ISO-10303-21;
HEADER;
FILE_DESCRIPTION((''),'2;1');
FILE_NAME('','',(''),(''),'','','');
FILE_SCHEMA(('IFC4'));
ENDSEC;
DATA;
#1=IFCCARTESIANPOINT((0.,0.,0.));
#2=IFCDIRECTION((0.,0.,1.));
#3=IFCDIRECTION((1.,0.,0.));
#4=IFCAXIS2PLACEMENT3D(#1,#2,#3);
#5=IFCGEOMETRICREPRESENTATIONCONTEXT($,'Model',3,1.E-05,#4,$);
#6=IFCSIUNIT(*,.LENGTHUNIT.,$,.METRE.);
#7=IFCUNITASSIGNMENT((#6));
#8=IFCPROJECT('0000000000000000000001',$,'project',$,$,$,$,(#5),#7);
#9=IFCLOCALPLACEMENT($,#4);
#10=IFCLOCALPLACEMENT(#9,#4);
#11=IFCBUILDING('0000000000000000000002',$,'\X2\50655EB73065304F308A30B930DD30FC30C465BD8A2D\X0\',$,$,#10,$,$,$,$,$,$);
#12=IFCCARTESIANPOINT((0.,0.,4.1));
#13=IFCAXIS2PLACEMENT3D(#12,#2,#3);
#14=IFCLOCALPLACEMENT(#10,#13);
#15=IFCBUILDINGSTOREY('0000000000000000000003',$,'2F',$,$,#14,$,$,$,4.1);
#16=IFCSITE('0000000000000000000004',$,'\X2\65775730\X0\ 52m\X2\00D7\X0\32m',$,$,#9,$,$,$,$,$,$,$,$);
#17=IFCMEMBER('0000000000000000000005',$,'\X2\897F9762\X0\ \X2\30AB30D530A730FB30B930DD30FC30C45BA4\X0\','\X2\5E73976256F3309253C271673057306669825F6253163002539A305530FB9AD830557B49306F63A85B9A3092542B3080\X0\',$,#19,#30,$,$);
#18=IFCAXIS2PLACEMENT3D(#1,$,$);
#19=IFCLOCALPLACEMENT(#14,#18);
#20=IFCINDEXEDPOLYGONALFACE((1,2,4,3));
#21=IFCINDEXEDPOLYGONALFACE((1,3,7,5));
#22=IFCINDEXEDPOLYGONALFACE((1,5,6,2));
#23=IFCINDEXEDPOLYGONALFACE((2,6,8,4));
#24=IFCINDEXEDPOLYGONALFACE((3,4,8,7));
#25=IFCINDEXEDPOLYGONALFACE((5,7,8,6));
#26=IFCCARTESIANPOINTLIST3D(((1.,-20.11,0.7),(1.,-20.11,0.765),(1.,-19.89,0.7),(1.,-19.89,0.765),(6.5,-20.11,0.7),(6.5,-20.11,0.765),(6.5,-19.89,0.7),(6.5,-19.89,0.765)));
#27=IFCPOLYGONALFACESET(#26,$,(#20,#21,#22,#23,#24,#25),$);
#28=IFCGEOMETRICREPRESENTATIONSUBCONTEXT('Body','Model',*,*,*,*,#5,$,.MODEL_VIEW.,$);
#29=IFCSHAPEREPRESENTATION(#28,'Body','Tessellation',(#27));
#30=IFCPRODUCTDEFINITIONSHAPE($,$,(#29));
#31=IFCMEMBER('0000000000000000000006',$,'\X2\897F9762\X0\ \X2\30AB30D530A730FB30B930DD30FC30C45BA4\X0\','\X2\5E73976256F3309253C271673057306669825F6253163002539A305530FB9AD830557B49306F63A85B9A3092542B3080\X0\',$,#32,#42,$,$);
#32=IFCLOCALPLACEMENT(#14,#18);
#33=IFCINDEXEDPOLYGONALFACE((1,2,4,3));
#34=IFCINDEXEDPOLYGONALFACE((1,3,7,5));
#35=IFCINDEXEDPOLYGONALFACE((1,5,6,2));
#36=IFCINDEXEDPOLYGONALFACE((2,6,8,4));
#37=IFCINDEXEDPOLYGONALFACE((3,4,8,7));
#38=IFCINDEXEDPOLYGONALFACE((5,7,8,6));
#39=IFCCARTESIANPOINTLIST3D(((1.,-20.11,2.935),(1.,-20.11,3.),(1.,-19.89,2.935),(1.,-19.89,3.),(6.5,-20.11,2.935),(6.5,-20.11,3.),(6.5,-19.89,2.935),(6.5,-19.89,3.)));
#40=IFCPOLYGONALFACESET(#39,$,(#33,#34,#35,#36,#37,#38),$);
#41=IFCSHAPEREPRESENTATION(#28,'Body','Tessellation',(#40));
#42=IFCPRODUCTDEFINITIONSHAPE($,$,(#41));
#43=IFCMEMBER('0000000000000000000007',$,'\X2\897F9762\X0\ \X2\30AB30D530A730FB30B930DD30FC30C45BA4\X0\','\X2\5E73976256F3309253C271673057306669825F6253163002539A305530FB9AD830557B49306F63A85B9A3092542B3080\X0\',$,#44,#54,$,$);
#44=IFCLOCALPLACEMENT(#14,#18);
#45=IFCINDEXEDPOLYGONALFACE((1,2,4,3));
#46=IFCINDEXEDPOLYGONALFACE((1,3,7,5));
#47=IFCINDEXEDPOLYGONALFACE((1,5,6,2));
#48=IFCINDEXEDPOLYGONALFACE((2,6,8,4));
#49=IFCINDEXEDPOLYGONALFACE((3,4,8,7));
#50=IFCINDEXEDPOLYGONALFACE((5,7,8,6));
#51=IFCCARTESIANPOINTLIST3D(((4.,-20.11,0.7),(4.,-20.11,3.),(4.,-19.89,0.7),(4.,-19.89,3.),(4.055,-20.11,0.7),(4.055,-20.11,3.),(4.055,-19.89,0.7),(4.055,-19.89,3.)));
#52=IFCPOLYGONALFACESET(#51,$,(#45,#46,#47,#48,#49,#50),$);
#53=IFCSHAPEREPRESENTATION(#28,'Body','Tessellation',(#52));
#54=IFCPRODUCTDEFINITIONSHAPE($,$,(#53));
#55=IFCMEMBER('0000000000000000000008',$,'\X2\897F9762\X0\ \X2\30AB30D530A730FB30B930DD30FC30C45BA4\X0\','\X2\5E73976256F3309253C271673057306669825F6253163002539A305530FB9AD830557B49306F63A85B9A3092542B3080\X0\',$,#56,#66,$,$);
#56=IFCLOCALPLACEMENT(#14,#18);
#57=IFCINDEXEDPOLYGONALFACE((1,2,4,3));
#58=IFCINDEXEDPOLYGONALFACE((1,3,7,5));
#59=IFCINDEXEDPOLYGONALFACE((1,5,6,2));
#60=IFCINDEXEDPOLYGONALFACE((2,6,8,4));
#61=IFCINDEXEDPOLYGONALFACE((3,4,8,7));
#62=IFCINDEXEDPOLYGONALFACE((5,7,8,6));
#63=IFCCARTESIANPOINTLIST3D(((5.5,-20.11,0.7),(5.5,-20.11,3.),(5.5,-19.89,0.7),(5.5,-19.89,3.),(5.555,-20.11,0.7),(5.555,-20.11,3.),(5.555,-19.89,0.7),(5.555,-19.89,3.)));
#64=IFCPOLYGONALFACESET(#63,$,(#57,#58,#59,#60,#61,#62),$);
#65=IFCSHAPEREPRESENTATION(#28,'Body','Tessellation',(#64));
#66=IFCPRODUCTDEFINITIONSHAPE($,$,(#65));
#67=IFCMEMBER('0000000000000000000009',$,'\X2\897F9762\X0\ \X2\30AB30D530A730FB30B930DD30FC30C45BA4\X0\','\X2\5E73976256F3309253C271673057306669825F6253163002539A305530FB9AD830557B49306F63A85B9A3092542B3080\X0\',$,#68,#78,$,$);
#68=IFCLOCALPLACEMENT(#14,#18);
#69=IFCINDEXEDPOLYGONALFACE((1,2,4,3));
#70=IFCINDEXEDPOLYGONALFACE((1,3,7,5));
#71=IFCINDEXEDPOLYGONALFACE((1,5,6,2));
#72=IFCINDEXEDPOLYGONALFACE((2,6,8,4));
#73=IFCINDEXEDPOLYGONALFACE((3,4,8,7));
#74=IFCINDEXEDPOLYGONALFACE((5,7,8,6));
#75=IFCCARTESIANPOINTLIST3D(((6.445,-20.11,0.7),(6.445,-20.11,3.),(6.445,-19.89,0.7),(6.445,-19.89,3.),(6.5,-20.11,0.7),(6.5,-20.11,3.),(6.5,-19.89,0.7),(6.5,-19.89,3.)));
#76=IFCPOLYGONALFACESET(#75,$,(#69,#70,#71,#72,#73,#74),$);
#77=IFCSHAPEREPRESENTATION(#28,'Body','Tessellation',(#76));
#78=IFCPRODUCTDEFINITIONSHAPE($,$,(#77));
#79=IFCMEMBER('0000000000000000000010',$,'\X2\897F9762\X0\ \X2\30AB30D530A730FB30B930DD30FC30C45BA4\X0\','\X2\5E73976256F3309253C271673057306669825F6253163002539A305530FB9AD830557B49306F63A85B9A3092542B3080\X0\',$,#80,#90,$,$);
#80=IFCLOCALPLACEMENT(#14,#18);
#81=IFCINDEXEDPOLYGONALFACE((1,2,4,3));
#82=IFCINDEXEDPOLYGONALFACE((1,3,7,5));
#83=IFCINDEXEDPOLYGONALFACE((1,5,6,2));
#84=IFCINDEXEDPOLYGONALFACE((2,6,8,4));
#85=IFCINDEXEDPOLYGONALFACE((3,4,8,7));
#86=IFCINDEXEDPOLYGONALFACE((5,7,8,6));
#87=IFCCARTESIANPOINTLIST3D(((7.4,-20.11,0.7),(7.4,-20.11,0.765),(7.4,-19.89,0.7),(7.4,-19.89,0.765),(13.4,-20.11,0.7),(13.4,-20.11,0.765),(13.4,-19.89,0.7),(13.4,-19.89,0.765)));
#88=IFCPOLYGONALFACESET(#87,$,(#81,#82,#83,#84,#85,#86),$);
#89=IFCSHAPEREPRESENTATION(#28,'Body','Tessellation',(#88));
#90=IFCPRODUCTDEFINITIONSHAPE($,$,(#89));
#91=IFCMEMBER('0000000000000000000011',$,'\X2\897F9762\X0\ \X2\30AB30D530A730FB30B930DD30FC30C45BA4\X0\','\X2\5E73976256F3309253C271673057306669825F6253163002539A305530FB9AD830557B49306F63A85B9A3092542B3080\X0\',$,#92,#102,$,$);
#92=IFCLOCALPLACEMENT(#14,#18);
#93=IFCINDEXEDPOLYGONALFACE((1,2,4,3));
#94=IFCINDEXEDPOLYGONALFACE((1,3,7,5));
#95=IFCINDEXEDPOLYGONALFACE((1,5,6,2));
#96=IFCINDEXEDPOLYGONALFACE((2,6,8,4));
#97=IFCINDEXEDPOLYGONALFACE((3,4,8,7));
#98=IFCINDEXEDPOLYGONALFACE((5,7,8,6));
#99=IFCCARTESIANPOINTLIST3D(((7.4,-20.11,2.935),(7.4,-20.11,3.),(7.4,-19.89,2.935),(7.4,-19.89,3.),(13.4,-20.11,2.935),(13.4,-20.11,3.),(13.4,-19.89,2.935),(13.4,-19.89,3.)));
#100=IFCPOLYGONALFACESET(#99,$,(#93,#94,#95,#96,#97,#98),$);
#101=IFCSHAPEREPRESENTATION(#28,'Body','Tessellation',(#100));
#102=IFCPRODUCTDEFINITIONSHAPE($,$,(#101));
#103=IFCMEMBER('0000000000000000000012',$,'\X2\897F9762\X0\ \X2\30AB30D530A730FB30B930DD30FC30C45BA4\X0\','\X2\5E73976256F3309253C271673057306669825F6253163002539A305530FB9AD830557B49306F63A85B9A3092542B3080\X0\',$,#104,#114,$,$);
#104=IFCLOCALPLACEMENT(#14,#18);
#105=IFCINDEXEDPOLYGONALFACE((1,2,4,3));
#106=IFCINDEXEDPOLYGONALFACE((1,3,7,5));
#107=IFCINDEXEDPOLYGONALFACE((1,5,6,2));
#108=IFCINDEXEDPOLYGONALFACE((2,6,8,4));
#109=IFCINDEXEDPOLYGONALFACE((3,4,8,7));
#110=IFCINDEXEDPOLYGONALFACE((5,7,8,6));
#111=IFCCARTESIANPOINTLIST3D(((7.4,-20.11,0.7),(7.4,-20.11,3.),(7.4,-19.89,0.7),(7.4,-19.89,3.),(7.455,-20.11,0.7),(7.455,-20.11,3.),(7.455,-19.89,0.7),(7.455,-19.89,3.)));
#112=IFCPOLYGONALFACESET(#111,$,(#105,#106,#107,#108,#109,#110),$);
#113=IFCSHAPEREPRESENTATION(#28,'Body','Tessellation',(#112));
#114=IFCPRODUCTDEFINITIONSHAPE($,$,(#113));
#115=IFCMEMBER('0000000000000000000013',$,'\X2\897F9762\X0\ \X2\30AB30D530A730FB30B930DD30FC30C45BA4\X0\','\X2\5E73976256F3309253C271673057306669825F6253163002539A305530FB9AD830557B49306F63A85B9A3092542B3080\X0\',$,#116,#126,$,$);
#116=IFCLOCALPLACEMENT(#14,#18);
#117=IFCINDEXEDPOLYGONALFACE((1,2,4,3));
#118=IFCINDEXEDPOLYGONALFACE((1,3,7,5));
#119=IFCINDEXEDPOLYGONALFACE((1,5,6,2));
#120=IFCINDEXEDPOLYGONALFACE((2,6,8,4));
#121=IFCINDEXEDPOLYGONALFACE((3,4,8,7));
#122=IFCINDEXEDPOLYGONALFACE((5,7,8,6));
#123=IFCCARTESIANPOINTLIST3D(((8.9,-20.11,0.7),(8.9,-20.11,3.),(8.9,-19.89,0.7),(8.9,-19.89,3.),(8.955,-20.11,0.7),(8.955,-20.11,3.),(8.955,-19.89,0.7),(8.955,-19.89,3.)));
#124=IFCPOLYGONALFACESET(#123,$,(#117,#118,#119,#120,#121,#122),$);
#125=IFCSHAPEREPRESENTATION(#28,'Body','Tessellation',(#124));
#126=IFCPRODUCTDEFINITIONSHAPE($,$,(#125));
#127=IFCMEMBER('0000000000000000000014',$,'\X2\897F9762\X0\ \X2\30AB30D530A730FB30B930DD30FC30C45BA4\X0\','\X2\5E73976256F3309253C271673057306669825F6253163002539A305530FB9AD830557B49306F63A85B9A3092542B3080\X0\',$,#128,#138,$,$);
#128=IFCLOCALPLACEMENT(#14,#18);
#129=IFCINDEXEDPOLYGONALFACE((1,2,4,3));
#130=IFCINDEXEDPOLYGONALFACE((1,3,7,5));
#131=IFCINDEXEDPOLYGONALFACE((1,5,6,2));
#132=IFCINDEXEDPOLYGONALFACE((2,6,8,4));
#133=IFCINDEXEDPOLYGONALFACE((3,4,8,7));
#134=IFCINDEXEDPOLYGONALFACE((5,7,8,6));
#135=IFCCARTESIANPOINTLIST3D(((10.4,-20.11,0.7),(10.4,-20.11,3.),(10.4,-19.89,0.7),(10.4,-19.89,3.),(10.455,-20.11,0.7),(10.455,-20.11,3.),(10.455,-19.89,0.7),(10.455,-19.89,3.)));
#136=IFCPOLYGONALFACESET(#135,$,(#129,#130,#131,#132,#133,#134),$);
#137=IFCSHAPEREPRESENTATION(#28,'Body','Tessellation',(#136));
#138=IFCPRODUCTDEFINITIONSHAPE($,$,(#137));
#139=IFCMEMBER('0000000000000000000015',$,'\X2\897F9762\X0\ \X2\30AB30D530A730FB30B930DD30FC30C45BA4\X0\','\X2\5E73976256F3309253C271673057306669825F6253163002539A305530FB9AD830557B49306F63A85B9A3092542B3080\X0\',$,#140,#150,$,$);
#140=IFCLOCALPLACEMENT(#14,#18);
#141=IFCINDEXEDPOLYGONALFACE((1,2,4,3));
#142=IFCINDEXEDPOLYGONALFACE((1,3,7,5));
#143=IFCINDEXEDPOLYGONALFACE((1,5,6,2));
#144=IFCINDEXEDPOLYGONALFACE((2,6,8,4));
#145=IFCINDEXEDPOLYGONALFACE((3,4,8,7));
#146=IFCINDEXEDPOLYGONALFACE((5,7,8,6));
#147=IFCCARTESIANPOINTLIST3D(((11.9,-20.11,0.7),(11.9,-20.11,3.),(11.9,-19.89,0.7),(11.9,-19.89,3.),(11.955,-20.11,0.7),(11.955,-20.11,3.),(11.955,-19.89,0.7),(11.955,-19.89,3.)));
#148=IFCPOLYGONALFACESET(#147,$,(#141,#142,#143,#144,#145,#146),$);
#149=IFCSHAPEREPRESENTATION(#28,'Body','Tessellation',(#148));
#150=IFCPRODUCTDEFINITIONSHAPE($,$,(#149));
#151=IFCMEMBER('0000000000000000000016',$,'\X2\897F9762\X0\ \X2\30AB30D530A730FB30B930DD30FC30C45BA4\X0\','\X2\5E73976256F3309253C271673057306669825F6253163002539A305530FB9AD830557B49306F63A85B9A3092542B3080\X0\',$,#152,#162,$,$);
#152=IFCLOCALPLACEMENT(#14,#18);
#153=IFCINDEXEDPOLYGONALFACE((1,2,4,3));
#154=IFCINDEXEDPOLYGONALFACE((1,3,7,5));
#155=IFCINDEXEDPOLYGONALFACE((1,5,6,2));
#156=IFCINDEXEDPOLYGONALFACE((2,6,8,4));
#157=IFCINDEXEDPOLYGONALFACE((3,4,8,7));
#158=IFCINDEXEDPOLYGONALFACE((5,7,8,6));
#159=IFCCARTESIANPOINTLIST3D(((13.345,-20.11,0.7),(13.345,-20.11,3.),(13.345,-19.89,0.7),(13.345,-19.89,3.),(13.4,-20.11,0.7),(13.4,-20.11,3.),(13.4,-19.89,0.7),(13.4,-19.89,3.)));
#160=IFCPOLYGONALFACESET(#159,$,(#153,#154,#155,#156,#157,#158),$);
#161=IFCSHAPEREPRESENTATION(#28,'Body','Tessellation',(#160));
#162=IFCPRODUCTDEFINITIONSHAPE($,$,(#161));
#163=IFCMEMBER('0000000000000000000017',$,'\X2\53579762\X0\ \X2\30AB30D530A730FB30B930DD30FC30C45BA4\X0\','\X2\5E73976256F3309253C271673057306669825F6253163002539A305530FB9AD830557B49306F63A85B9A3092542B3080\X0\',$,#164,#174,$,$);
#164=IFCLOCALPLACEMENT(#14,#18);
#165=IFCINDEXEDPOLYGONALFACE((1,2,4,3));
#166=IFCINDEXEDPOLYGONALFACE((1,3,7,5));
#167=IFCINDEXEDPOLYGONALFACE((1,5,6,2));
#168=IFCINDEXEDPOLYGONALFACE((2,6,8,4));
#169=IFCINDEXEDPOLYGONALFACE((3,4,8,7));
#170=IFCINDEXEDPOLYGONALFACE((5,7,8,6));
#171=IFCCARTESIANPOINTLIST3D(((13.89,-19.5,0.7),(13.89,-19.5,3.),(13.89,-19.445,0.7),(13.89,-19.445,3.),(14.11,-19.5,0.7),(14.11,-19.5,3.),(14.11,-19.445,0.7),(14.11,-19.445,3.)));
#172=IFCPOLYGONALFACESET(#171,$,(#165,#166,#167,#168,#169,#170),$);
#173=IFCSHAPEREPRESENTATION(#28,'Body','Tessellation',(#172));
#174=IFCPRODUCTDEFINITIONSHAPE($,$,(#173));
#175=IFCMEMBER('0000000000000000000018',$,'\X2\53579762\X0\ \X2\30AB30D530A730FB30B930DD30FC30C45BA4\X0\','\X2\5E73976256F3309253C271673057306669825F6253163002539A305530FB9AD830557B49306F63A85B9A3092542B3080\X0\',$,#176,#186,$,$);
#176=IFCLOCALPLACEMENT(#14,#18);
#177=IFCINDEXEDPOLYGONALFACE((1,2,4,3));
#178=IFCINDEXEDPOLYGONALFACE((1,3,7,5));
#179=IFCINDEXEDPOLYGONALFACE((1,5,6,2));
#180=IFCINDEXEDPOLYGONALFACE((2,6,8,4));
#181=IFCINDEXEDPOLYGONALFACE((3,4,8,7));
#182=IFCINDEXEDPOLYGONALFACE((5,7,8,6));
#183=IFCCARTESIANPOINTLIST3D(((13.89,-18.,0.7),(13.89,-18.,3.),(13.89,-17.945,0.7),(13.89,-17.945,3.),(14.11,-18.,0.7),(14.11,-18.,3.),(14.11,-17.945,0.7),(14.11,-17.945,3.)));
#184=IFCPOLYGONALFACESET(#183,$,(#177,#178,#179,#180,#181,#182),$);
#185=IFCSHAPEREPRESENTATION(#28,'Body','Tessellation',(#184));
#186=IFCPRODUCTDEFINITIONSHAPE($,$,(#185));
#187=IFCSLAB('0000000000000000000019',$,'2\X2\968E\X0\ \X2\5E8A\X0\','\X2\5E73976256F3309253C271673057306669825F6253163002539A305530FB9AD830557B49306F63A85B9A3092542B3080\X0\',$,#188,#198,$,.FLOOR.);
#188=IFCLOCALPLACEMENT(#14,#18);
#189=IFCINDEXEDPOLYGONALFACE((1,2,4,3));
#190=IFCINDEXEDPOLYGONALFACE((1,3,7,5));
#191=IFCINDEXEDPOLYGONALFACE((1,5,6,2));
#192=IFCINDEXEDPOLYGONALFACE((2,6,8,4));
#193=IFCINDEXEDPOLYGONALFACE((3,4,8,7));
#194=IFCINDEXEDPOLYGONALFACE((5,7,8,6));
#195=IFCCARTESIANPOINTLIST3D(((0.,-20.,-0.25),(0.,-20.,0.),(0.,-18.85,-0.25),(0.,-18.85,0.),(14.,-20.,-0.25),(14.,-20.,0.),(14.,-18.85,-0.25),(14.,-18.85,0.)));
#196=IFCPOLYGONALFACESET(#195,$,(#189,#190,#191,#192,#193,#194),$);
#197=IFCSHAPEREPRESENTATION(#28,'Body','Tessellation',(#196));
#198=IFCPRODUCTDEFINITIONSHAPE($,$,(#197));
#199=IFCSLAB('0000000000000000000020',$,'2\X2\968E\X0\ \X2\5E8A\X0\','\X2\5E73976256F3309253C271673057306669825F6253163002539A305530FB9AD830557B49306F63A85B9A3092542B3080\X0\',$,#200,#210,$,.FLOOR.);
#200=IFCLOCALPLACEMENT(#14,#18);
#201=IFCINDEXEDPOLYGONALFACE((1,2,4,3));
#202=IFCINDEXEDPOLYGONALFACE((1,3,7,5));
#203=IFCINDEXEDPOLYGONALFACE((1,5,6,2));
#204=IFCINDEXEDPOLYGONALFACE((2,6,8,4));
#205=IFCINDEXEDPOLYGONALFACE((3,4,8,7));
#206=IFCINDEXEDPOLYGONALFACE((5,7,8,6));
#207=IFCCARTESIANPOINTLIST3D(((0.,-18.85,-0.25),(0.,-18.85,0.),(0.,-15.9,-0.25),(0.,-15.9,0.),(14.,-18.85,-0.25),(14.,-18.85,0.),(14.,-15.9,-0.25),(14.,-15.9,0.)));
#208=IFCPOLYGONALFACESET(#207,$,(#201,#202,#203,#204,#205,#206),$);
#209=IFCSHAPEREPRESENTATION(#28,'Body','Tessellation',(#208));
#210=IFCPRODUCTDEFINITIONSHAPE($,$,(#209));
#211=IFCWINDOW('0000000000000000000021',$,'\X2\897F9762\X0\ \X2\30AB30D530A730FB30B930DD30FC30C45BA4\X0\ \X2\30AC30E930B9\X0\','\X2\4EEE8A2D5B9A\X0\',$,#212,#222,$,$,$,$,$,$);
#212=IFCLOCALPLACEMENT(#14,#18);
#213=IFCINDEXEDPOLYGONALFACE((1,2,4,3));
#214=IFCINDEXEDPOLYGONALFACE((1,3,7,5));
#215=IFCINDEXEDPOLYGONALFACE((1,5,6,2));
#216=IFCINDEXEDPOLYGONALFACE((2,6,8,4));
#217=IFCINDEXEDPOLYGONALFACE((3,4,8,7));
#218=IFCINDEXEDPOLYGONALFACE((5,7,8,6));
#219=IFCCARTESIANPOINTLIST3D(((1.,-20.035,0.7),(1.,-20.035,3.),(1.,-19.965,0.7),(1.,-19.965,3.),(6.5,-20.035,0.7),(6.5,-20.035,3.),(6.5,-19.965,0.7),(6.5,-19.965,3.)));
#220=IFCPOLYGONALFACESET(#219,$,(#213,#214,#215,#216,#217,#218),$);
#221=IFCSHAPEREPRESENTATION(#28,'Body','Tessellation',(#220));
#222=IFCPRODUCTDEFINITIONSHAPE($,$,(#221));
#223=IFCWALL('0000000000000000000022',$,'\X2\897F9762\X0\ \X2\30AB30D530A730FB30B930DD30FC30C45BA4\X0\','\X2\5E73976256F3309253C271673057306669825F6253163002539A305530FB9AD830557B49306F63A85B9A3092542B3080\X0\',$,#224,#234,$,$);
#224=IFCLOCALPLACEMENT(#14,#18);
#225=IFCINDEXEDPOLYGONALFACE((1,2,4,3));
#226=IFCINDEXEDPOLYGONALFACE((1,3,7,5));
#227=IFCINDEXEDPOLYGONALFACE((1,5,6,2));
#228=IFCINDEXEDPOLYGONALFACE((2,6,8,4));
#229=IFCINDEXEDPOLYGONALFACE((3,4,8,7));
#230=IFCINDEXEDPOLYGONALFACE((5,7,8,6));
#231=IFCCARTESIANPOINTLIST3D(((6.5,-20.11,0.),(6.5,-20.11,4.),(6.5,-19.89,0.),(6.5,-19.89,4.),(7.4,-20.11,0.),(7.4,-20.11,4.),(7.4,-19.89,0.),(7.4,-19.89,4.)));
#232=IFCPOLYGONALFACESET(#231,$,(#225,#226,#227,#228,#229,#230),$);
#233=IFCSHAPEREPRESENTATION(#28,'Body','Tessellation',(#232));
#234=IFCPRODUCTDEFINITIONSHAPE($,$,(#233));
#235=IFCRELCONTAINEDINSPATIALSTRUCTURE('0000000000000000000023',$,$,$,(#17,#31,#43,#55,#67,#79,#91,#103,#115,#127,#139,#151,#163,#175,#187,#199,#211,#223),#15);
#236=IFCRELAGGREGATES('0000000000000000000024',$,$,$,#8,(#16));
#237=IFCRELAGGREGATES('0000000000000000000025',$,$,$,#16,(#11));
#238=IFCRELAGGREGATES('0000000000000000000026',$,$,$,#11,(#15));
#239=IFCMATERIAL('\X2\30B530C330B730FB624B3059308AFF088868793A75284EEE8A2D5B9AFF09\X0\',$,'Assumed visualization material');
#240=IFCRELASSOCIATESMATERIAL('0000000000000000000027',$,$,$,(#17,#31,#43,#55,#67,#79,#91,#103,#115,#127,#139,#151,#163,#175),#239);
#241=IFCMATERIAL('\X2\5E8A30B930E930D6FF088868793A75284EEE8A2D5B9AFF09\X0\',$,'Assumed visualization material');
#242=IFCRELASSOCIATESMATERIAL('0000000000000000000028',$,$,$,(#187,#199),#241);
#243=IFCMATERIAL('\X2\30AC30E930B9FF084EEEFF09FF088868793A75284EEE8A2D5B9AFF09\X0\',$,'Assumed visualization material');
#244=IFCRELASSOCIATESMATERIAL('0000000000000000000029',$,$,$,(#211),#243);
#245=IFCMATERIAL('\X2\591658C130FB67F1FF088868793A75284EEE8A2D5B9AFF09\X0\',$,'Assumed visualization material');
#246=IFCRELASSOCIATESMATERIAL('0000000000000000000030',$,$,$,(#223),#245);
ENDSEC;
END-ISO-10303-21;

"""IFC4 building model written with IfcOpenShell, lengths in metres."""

from ifc_helpers import new_model, si_unit, frame, origin_with_axes, place, context, subcontext, project, spatial, rectangle, extrude, material, element, save


model = new_model("IFC4")

# Units and contexts
model_context = context("Model", 3, precision=1e-05, world=origin_with_axes())
body_context = subcontext(model_context, "Body", "Model", "MODEL_VIEW")
ifc_project = project(units=[si_unit("LENGTHUNIT", "METRE")], contexts=[model_context])

# Site, building, storey
site_placement = place(None, origin_with_axes())
site = spatial("IfcSite", under=ifc_project, at=site_placement, Name="敷地 52m×32m")
building_placement = place(site_placement, origin_with_axes())
building = spatial("IfcBuilding", under=site, at=building_placement, Name="健康づくりスポーツ施設")
storey_placement = place(building_placement, frame((0.0, 0.0, 4.1), z_axis=(0.0, 0.0, 1.0), x_axis=(1.0, 0.0, 0.0)))
storey = spatial("IfcBuildingStorey", under=building, at=storey_placement, Name="2F", Elevation=4.1)

# Members
ifc_material_1 = material(Name="サッシ・手すり（表示用仮設定）", Category="Assumed visualization material")
for number, where, z_axis, x_axis, name in (
    (1, (3.75, -20.0, 0.7), (0.0, 0.0, 1.0), (1.0, 0.0, 0.0), "西面 カフェ・スポーツ室"),
    (2, (3.75, -20.0, 2.935), (0.0, 0.0, 1.0), (1.0, 0.0, 0.0), "西面 カフェ・スポーツ室"),
):
    element("IfcMember", number, at=place(storey_placement, frame(where, z_axis=z_axis, x_axis=x_axis)), inside=storey, material=ifc_material_1, Name=name, Description="平面図を参照して概形化。厚さ・高さ等は推定を含む", context=body_context, shape_type="SweptSolid", body=[
        extrude(rectangle(XDim=5.5, YDim=0.22), origin_with_axes(), (0.0, 0.0, 1.0), 0.065),
    ])
for number, where, z_axis, x_axis, name in (
    (3, (4.0275, -20.0, 0.7), (0.0, 0.0, 1.0), (1.0, 0.0, 0.0), "西面 カフェ・スポーツ室"),
    (4, (5.5275, -20.0, 0.7), (0.0, 0.0, 1.0), (1.0, 0.0, 0.0), "西面 カフェ・スポーツ室"),
    (5, (6.4725, -20.0, 0.7), (0.0, 0.0, 1.0), (1.0, 0.0, 0.0), "西面 カフェ・スポーツ室"),
):
    element("IfcMember", number, at=place(storey_placement, frame(where, z_axis=z_axis, x_axis=x_axis)), inside=storey, material=ifc_material_1, Name=name, Description="平面図を参照して概形化。厚さ・高さ等は推定を含む", context=body_context, shape_type="SweptSolid", body=[
        extrude(rectangle(XDim=0.055, YDim=0.22), origin_with_axes(), (0.0, 0.0, 1.0), 2.3),
    ])
for number, where, z_axis, x_axis, name in (
    (6, (10.4, -20.0, 0.7), (0.0, 0.0, 1.0), (1.0, 0.0, 0.0), "西面 カフェ・スポーツ室"),
    (7, (10.4, -20.0, 2.935), (0.0, 0.0, 1.0), (1.0, 0.0, 0.0), "西面 カフェ・スポーツ室"),
):
    element("IfcMember", number, at=place(storey_placement, frame(where, z_axis=z_axis, x_axis=x_axis)), inside=storey, material=ifc_material_1, Name=name, Description="平面図を参照して概形化。厚さ・高さ等は推定を含む", context=body_context, shape_type="SweptSolid", body=[
        extrude(rectangle(XDim=6.0, YDim=0.22), origin_with_axes(), (0.0, 0.0, 1.0), 0.065),
    ])
for number, where, z_axis, x_axis, name in (
    (8, (7.4275, -20.0, 0.7), (0.0, 0.0, 1.0), (1.0, 0.0, 0.0), "西面 カフェ・スポーツ室"),
    (9, (8.9275, -20.0, 0.7), (0.0, 0.0, 1.0), (1.0, 0.0, 0.0), "西面 カフェ・スポーツ室"),
    (10, (10.4275, -20.0, 0.7), (0.0, 0.0, 1.0), (1.0, 0.0, 0.0), "西面 カフェ・スポーツ室"),
    (11, (11.9275, -20.0, 0.7), (0.0, 0.0, 1.0), (1.0, 0.0, 0.0), "西面 カフェ・スポーツ室"),
    (12, (13.3725, -20.0, 0.7), (0.0, 0.0, 1.0), (1.0, 0.0, 0.0), "西面 カフェ・スポーツ室"),
):
    element("IfcMember", number, at=place(storey_placement, frame(where, z_axis=z_axis, x_axis=x_axis)), inside=storey, material=ifc_material_1, Name=name, Description="平面図を参照して概形化。厚さ・高さ等は推定を含む", context=body_context, shape_type="SweptSolid", body=[
        extrude(rectangle(XDim=0.055, YDim=0.22), origin_with_axes(), (0.0, 0.0, 1.0), 2.3),
    ])
member_1_placement = place(storey_placement, frame((14.0, -19.4725, 0.7), z_axis=(0.0, 0.0, 1.0), x_axis=(1.0, 0.0, 0.0)))
element("IfcMember", 13, at=member_1_placement, inside=storey, material=ifc_material_1, Name="南面 カフェ・スポーツ室", Description="平面図を参照して概形化。厚さ・高さ等は推定を含む", context=body_context, shape_type="SweptSolid", body=[
    extrude(rectangle(XDim=0.22, YDim=0.055), origin_with_axes(), (0.0, 0.0, 1.0), 2.3),
])
member_2_placement = place(storey_placement, frame((14.0, -17.9725, 0.7), z_axis=(0.0, 0.0, 1.0), x_axis=(1.0, 0.0, 0.0)))
element("IfcMember", 14, at=member_2_placement, inside=storey, material=ifc_material_1, Name="南面 カフェ・スポーツ室", Description="平面図を参照して概形化。厚さ・高さ等は推定を含む", context=body_context, shape_type="SweptSolid", body=[
    extrude(rectangle(XDim=0.22, YDim=0.055), origin_with_axes(), (0.0, 0.0, 1.0), 2.3),
])

# Slabs
ifc_material_2 = material(Name="床スラブ（表示用仮設定）", Category="Assumed visualization material")
slab_1_placement = place(storey_placement, frame((7.0, -19.425, -0.25), z_axis=(0.0, 0.0, 1.0), x_axis=(1.0, 0.0, 0.0)))
element("IfcSlab", 15, at=slab_1_placement, inside=storey, material=ifc_material_2, Name="2階 床", Description="平面図を参照して概形化。厚さ・高さ等は推定を含む", PredefinedType="FLOOR", context=body_context, shape_type="SweptSolid", body=[
    extrude(rectangle(XDim=14.0, YDim=1.15), origin_with_axes(), (0.0, 0.0, 1.0), 0.25),
])
slab_2_placement = place(storey_placement, frame((7.0, -17.375, -0.25), z_axis=(0.0, 0.0, 1.0), x_axis=(1.0, 0.0, 0.0)))
element("IfcSlab", 16, at=slab_2_placement, inside=storey, material=ifc_material_2, Name="2階 床", Description="平面図を参照して概形化。厚さ・高さ等は推定を含む", PredefinedType="FLOOR", context=body_context, shape_type="SweptSolid", body=[
    extrude(rectangle(XDim=14.0, YDim=2.95), origin_with_axes(), (0.0, 0.0, 1.0), 0.25),
])

# Window
ifc_material_3 = material(Name="ガラス（仮）（表示用仮設定）", Category="Assumed visualization material")
window_1_placement = place(storey_placement, frame((3.75, -20.0, 0.7), z_axis=(0.0, 0.0, 1.0), x_axis=(1.0, 0.0, 0.0)))
element("IfcWindow", 17, at=window_1_placement, inside=storey, material=ifc_material_3, Name="西面 カフェ・スポーツ室 ガラス", Description="仮設定", context=body_context, shape_type="SweptSolid", body=[
    extrude(rectangle(XDim=5.5, YDim=0.07), origin_with_axes(), (0.0, 0.0, 1.0), 2.3),
])

# Wall
ifc_material_4 = material(Name="外壁・柱（表示用仮設定）", Category="Assumed visualization material")
wall_1_placement = place(storey_placement, frame((6.95, -20.0, 0.0), z_axis=(0.0, 0.0, 1.0), x_axis=(1.0, 0.0, 0.0)))
element("IfcWall", 18, at=wall_1_placement, inside=storey, material=ifc_material_4, Name="西面 カフェ・スポーツ室", Description="平面図を参照して概形化。厚さ・高さ等は推定を含む", context=body_context, shape_type="SweptSolid", body=[
    extrude(rectangle(XDim=0.9, YDim=0.22), origin_with_axes(), (0.0, 0.0, 1.0), 4.0),
])

save(model, "model.ifc")
